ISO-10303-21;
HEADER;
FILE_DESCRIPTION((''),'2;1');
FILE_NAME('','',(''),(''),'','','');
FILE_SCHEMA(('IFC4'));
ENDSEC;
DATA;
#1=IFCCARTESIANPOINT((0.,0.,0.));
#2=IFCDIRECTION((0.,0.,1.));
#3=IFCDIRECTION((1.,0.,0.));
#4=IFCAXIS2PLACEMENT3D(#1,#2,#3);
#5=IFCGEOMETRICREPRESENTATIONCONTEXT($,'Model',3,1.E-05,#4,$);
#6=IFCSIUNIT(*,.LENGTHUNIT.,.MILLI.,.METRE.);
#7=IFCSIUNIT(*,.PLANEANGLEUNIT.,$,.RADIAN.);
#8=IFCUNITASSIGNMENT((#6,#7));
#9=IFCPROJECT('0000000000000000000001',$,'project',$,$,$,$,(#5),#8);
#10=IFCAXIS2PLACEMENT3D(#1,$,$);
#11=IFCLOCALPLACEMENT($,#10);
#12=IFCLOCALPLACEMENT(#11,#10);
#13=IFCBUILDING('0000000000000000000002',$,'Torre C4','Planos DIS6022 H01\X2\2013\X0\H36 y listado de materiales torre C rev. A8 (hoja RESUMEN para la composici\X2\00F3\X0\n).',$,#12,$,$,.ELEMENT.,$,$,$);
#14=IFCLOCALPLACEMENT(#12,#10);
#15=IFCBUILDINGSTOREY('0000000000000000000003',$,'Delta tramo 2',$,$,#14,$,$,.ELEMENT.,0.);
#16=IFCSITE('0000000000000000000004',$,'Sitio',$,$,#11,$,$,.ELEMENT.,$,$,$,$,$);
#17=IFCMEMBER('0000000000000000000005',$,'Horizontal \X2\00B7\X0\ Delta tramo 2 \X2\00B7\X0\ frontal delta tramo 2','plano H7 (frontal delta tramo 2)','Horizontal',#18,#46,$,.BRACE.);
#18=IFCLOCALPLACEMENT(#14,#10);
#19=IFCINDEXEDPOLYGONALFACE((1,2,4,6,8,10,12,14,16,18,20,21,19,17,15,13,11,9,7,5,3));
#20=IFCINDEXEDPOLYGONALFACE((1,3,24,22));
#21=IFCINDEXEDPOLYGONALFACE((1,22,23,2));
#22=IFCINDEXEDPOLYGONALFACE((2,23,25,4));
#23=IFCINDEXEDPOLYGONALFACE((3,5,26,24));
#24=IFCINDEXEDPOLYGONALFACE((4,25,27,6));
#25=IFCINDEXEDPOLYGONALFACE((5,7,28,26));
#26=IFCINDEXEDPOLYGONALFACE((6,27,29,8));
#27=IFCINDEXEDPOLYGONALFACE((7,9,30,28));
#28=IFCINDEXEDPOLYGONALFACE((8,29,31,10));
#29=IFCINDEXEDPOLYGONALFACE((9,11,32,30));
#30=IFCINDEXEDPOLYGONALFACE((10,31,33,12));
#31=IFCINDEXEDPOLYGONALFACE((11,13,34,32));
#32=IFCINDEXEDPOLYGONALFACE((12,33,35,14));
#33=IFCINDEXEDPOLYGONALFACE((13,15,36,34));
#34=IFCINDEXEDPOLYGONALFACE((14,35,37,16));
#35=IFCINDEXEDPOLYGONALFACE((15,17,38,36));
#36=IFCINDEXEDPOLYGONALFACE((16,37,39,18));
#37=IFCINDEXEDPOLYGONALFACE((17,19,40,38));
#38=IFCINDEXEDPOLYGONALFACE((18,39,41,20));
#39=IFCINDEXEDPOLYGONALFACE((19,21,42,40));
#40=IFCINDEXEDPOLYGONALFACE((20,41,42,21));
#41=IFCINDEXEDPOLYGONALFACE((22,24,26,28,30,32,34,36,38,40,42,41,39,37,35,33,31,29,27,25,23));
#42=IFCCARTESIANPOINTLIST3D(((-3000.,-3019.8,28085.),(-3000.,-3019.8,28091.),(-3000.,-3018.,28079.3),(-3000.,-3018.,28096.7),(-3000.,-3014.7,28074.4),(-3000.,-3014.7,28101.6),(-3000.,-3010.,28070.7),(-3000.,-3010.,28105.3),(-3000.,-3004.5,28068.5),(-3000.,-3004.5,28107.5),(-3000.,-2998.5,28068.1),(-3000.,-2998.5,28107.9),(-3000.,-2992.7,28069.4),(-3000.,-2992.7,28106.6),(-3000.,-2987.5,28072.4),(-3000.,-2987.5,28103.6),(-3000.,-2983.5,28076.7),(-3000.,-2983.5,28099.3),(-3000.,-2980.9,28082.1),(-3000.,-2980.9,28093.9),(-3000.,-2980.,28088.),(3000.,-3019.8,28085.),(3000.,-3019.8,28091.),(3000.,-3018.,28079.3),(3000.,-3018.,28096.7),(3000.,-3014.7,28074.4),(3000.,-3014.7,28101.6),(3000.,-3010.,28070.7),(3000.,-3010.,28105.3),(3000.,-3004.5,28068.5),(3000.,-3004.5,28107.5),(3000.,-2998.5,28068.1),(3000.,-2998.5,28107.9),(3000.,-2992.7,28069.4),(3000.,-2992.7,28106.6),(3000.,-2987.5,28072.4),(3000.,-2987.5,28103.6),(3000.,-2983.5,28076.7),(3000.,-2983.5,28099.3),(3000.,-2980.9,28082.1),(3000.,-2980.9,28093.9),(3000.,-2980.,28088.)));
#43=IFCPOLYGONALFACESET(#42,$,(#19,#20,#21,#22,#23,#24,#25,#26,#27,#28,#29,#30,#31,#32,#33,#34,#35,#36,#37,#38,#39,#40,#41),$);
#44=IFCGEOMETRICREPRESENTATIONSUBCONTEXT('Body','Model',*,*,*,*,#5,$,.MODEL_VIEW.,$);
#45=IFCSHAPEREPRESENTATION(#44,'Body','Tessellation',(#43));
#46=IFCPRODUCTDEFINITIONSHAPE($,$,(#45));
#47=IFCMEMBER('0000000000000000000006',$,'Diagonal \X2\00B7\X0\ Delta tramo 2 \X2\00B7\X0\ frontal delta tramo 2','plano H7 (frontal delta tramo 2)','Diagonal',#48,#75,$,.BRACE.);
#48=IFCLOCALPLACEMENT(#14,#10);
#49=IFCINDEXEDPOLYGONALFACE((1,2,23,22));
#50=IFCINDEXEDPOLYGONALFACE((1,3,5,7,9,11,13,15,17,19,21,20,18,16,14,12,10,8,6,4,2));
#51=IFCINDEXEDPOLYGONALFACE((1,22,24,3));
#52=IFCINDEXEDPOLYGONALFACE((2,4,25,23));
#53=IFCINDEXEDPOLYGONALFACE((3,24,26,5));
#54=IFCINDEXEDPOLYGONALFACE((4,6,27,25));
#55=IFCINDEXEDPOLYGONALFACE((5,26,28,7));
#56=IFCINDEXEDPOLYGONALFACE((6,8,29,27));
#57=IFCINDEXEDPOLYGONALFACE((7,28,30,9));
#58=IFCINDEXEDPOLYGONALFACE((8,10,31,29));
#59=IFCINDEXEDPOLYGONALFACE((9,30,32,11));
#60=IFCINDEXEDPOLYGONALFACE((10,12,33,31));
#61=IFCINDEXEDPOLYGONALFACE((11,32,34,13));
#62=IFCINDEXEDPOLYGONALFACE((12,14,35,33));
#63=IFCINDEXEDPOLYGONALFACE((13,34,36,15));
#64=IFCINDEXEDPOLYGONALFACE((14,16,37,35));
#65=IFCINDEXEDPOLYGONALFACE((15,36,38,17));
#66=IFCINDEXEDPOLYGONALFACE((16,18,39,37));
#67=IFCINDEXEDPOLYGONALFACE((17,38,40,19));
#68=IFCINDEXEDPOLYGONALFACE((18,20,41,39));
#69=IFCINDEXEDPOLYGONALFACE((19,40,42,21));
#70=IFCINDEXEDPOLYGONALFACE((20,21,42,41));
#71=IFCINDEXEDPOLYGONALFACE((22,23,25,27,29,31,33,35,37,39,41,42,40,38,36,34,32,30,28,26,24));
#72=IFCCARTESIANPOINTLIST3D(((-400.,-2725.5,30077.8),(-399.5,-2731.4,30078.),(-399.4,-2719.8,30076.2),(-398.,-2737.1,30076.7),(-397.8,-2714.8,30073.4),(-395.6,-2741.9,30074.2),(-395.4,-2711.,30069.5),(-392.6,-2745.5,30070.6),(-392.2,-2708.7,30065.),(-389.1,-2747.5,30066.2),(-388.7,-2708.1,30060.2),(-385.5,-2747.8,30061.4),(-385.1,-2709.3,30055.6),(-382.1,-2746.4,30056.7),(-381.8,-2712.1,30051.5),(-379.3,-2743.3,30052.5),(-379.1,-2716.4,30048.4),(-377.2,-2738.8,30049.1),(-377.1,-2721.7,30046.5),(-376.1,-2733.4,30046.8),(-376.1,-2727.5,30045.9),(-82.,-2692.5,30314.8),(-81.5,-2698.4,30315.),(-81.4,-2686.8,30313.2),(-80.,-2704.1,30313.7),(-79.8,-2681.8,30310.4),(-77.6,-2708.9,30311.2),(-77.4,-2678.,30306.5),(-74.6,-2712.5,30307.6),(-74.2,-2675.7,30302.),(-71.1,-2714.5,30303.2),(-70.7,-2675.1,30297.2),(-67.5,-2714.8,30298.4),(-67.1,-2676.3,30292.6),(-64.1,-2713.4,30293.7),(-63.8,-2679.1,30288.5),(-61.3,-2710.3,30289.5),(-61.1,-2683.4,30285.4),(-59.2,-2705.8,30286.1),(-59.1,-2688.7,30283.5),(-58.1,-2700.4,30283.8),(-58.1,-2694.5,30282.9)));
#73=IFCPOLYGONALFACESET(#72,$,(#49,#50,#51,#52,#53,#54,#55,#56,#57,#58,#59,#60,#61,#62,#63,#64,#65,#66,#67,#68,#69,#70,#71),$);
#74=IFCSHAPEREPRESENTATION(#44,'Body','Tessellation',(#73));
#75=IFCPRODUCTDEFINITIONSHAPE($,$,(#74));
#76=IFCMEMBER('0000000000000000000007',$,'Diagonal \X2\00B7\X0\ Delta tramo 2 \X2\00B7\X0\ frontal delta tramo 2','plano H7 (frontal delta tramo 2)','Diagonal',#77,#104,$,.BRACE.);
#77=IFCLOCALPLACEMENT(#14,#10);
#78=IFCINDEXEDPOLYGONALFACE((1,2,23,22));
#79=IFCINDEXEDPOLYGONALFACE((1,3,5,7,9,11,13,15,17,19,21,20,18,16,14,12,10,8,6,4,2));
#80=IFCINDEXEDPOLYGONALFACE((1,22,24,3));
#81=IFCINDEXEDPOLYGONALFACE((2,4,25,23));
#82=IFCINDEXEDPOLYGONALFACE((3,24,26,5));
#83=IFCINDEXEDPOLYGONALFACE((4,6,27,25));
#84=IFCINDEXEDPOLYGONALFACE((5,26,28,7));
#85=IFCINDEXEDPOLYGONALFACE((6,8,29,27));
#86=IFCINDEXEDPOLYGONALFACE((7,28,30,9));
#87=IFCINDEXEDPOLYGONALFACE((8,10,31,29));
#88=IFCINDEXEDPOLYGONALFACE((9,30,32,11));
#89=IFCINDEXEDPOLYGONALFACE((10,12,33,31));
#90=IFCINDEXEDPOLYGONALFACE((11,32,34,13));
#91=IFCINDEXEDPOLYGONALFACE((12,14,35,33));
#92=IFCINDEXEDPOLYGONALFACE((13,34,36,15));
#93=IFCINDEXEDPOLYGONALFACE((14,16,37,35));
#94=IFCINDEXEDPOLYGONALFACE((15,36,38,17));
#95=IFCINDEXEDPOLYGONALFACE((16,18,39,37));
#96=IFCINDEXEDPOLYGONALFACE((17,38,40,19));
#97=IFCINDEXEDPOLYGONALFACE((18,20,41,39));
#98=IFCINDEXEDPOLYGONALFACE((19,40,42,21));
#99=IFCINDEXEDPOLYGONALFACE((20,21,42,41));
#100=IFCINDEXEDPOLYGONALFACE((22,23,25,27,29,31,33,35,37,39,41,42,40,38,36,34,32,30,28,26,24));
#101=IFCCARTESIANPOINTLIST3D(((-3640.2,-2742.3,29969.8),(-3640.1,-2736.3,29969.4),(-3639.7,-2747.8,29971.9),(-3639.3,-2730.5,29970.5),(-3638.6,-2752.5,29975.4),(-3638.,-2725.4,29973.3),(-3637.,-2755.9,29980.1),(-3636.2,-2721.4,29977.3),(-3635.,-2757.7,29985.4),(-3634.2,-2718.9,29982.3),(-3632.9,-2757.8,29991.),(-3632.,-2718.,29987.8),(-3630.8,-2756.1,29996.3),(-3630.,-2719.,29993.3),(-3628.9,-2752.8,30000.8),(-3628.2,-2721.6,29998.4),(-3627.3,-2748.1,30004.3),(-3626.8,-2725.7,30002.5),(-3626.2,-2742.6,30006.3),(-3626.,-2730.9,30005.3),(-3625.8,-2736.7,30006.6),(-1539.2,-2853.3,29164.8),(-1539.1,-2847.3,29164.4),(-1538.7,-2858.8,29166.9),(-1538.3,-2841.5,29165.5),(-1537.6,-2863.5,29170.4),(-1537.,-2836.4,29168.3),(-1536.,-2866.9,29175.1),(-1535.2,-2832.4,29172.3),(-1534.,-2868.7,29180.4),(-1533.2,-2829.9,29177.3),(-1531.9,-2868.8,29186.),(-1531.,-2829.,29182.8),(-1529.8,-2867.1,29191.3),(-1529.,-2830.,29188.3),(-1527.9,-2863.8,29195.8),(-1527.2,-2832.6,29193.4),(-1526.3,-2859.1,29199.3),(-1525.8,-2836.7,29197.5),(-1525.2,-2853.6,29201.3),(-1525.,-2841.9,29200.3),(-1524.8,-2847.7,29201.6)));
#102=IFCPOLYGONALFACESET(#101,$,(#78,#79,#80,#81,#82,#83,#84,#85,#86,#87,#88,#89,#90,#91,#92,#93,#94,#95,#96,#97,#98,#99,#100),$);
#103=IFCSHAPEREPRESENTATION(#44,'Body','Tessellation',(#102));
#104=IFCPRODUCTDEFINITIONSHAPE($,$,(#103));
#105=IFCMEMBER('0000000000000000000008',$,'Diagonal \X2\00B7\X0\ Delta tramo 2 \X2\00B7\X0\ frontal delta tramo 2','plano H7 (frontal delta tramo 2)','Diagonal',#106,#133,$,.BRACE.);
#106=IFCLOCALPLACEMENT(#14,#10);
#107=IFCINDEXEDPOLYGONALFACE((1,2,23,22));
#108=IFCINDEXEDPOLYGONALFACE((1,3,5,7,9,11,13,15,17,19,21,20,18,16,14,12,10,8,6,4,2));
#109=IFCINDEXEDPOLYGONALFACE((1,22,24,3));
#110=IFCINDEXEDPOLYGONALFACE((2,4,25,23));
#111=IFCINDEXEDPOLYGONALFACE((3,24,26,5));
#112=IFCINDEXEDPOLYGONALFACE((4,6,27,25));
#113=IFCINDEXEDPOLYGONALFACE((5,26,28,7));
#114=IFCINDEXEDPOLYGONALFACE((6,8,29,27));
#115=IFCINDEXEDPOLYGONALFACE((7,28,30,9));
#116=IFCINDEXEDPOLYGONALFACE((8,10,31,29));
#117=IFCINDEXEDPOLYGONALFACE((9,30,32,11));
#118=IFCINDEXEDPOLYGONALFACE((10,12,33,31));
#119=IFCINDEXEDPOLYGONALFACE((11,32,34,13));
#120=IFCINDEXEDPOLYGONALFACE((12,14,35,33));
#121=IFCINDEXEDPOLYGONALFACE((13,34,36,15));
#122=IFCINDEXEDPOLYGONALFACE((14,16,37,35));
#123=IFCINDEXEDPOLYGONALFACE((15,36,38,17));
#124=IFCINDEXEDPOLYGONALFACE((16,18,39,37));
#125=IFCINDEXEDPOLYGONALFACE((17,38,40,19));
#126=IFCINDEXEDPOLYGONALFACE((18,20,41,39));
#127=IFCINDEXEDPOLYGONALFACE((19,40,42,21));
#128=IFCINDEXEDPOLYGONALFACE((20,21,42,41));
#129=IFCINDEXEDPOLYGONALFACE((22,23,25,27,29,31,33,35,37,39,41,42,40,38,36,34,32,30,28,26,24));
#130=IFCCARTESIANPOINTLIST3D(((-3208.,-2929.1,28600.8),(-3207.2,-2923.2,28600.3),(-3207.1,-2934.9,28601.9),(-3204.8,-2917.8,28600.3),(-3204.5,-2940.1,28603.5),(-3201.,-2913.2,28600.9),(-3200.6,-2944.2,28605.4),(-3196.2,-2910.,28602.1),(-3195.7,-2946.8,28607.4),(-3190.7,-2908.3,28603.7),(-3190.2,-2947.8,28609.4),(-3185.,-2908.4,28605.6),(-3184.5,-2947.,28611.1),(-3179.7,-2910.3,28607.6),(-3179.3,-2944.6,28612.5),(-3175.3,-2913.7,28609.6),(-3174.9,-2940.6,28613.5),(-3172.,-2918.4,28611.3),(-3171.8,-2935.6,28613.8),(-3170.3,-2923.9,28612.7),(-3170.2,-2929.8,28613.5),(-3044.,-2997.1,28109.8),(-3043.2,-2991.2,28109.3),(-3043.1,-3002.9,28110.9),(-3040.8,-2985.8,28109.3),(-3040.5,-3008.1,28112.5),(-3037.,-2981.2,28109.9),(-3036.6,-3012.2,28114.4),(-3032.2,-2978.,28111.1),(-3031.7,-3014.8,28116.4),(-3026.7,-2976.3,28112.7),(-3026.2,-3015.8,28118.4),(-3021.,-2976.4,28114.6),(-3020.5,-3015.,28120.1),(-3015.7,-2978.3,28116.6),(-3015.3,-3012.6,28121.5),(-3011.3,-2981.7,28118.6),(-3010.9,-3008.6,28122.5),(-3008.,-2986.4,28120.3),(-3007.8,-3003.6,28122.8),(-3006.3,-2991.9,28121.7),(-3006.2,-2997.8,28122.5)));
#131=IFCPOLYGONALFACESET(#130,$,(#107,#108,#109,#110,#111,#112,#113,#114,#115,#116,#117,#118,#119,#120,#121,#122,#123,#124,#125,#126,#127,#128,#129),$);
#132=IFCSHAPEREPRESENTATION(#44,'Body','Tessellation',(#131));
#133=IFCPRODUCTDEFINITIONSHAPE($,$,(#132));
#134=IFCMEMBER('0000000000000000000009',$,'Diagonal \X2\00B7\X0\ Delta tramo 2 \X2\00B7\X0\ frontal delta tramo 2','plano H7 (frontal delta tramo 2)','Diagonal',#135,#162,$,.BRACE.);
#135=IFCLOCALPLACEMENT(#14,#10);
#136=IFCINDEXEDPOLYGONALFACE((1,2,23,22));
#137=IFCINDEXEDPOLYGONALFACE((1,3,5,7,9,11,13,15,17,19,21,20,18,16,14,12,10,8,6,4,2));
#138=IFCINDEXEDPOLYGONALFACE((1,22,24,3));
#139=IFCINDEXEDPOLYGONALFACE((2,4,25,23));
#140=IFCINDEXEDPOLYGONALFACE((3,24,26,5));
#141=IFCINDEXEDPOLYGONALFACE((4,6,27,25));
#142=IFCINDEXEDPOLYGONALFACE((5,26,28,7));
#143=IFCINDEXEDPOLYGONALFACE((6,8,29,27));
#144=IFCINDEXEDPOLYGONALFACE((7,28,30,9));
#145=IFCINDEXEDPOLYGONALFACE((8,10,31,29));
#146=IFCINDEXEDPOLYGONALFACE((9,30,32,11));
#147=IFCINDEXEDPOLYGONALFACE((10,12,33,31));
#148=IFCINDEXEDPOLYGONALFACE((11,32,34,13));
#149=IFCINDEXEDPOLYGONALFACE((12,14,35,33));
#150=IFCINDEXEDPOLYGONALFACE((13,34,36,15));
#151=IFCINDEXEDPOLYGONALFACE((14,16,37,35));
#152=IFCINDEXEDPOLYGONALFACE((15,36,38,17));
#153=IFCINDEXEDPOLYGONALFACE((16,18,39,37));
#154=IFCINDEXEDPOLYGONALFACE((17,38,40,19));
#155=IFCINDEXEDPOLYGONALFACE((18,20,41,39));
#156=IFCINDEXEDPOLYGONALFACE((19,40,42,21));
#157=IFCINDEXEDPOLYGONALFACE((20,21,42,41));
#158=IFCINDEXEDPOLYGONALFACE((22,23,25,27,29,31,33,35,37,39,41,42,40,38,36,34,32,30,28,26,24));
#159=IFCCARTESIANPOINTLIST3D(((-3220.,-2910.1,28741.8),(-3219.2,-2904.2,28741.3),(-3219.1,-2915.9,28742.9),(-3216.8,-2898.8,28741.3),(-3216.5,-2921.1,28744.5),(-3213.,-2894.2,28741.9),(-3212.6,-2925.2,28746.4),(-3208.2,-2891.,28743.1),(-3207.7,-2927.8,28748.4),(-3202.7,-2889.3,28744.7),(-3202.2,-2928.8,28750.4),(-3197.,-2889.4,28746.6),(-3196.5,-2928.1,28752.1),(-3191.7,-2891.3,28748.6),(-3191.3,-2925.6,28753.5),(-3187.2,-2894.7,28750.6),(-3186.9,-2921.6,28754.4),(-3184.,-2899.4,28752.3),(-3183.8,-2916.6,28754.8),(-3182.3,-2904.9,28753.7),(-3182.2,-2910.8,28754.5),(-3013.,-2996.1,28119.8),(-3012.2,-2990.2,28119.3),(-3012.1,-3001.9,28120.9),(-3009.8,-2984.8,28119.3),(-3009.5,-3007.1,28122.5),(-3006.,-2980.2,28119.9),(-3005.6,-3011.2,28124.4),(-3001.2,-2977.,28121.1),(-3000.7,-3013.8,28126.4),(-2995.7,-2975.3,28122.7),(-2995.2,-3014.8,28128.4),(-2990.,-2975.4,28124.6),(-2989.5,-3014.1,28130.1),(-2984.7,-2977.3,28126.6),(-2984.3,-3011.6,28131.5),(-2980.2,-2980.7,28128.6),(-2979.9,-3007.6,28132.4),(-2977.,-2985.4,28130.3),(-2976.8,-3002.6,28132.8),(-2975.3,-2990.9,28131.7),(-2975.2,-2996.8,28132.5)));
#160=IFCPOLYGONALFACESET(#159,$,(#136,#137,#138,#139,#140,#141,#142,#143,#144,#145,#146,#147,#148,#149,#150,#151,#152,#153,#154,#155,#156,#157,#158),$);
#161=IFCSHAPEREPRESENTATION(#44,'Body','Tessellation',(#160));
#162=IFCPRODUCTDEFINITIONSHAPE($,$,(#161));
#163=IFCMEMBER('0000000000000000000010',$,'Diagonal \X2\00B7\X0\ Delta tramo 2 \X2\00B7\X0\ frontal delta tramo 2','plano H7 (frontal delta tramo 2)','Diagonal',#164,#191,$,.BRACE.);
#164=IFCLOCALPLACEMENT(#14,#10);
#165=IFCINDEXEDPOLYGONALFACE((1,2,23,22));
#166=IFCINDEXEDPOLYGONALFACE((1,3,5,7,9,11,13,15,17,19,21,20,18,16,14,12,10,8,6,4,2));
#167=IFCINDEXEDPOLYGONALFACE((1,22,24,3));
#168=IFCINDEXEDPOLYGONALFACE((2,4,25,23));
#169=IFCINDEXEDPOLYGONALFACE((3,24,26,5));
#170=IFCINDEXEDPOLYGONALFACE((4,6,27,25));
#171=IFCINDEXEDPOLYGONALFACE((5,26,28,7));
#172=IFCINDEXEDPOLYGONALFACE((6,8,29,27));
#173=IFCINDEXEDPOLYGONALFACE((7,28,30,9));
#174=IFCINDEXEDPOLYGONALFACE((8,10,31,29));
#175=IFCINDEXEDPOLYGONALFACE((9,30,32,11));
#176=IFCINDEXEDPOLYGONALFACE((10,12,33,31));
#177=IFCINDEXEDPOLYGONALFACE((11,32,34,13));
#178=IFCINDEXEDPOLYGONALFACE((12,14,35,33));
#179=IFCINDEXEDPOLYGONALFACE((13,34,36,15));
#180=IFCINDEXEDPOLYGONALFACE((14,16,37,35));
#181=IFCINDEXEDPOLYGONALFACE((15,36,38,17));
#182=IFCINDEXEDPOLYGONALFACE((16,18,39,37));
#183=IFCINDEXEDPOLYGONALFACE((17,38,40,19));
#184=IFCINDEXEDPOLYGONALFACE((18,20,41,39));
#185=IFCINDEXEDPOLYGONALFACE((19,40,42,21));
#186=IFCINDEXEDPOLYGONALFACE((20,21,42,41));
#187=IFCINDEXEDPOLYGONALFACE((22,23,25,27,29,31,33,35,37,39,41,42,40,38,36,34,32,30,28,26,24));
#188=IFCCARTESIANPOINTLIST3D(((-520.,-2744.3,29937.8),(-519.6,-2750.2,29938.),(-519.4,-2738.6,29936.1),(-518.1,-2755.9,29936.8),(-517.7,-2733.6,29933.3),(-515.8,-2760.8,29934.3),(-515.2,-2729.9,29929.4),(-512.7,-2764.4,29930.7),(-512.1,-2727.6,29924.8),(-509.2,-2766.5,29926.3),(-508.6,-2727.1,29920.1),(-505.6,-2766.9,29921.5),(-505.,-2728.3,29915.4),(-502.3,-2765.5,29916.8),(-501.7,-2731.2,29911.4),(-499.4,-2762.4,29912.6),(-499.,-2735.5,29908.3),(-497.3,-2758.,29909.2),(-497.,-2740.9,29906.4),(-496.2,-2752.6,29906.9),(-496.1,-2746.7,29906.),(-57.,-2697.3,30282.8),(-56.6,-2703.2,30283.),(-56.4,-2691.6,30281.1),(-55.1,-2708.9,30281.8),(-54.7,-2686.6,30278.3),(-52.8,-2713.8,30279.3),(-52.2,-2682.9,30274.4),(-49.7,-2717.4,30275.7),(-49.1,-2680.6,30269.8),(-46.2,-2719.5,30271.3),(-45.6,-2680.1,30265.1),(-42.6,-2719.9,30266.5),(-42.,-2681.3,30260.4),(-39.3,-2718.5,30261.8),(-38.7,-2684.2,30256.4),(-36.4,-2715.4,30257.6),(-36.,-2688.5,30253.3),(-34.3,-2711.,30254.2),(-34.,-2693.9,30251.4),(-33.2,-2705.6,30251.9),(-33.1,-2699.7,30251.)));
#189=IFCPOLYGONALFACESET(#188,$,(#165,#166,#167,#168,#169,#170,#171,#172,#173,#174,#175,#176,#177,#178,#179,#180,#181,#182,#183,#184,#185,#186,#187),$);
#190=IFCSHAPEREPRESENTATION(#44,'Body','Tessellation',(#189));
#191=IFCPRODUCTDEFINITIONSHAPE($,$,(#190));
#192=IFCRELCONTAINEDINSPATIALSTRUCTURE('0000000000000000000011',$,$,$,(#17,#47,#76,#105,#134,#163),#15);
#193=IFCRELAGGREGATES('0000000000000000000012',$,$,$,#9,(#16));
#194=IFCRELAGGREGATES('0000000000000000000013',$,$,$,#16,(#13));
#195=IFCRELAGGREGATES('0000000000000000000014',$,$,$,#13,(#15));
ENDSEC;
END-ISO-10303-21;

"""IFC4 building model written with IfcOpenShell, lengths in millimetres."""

from ifc_helpers import new_model, si_unit, frame, origin, origin_with_axes, place, context, subcontext, project, spatial, circle, extrude, element, save


model = new_model("IFC4")

# Units and contexts
model_context = context("Model", 3, precision=1e-05, world=origin_with_axes())
body_context = subcontext(model_context, "Body", "Model", "MODEL_VIEW")
ifc_project = project(units=[si_unit("LENGTHUNIT", "METRE", prefix="MILLI"), si_unit("PLANEANGLEUNIT", "RADIAN")], contexts=[model_context])

# Site, building, storey
site_placement = place(None, origin())
site = spatial("IfcSite", under=ifc_project, at=site_placement, Name="Sitio", CompositionType="ELEMENT")
building_placement = place(site_placement, origin())
building = spatial("IfcBuilding", under=site, at=building_placement, Name="Torre C4", Description="Planos DIS6022 H01–H36 y listado de materiales torre C rev. A8 (hoja RESUMEN para la composición).", CompositionType="ELEMENT")
storey_placement = place(building_placement, origin())
storey = spatial("IfcBuildingStorey", under=building, at=storey_placement, Name="Delta tramo 2", CompositionType="ELEMENT", Elevation=0.0)

# Members
member_1_placement = place(storey_placement, frame((-3000.0, -3000.0, 28088.0), z_axis=(1.0, 0.0, 0.0), x_axis=(0.0, 1.0, 0.0)))
element("IfcMember", 1, at=member_1_placement, inside=storey, Name="Horizontal · Delta tramo 2 · frontal delta tramo 2", Description="plano H7 (frontal delta tramo 2)", ObjectType="Horizontal", PredefinedType="BRACE", context=body_context, shape_type="SweptSolid", body=[
    extrude(circle(Radius=20.0), None, (0.0, 0.0, 1.0), 6000.0),
])
member_2_placement = place(storey_placement, frame((-70.0, -2695.0, 30299.0), z_axis=(-0.79905, -0.08292, -0.595519), x_axis=(-0.036005, 0.995266, -0.09027)))
element("IfcMember", 2, at=member_2_placement, inside=storey, Name="Diagonal · Delta tramo 2 · frontal delta tramo 2", Description="plano H7 (frontal delta tramo 2)", ObjectType="Diagonal", PredefinedType="BRACE", context=body_context, shape_type="SweptSolid", body=[
    extrude(circle(Radius=20.0), None, (0.0, 0.0, 1.0), 398.0),
])
member_3_placement = place(storey_placement, frame((-1532.0, -2849.0, 29183.0), z_axis=(-0.932669, 0.049275, 0.357353), x_axis=(0.152168, 0.951918, 0.26589)))
element("IfcMember", 3, at=member_3_placement, inside=storey, Name="Diagonal · Delta tramo 2 · frontal delta tramo 2", Description="plano H7 (frontal delta tramo 2)", ObjectType="Diagonal", PredefinedType="BRACE", context=body_context, shape_type="SweptSolid", body=[
    extrude(circle(Radius=20.0), None, (0.0, 0.0, 1.0), 2252.7),
])
member_4_placement = place(storey_placement, frame((-3025.0, -2996.0, 28116.0), z_axis=(-0.314109, 0.13024, 0.940411), x_axis=(0.687135, 0.714708, 0.130529)))
element("IfcMember", 4, at=member_4_placement, inside=storey, Name="Diagonal · Delta tramo 2 · frontal delta tramo 2", Description="plano H7 (frontal delta tramo 2)", ObjectType="Diagonal", PredefinedType="BRACE", context=body_context, shape_type="SweptSolid", body=[
    extrude(circle(Radius=20.0), None, (0.0, 0.0, 1.0), 522.1),
])
member_5_placement = place(storey_placement, frame((-2994.0, -2995.0, 28126.0), z_axis=(-0.313087, 0.130075, 0.940775), x_axis=(0.687514, 0.714436, 0.130023)))
element("IfcMember", 5, at=member_5_placement, inside=storey, Name="Diagonal · Delta tramo 2 · frontal delta tramo 2", Description="plano H7 (frontal delta tramo 2)", ObjectType="Diagonal", PredefinedType="BRACE", context=body_context, shape_type="SweptSolid", body=[
    extrude(circle(Radius=20.0), None, (0.0, 0.0, 1.0), 661.2),
])
member_6_placement = place(storey_placement, frame((-45.0, -2700.0, 30267.0), z_axis=(-0.799223, -0.081131, -0.595533), x_axis=(-0.028395, 0.994838, -0.097421)))
element("IfcMember", 6, at=member_6_placement, inside=storey, Name="Diagonal · Delta tramo 2 · frontal delta tramo 2", Description="plano H7 (frontal delta tramo 2)", ObjectType="Diagonal", PredefinedType="BRACE", context=body_context, shape_type="SweptSolid", body=[
    extrude(circle(Radius=20.0), None, (0.0, 0.0, 1.0), 579.3),
])

save(model, "model.ifc")
